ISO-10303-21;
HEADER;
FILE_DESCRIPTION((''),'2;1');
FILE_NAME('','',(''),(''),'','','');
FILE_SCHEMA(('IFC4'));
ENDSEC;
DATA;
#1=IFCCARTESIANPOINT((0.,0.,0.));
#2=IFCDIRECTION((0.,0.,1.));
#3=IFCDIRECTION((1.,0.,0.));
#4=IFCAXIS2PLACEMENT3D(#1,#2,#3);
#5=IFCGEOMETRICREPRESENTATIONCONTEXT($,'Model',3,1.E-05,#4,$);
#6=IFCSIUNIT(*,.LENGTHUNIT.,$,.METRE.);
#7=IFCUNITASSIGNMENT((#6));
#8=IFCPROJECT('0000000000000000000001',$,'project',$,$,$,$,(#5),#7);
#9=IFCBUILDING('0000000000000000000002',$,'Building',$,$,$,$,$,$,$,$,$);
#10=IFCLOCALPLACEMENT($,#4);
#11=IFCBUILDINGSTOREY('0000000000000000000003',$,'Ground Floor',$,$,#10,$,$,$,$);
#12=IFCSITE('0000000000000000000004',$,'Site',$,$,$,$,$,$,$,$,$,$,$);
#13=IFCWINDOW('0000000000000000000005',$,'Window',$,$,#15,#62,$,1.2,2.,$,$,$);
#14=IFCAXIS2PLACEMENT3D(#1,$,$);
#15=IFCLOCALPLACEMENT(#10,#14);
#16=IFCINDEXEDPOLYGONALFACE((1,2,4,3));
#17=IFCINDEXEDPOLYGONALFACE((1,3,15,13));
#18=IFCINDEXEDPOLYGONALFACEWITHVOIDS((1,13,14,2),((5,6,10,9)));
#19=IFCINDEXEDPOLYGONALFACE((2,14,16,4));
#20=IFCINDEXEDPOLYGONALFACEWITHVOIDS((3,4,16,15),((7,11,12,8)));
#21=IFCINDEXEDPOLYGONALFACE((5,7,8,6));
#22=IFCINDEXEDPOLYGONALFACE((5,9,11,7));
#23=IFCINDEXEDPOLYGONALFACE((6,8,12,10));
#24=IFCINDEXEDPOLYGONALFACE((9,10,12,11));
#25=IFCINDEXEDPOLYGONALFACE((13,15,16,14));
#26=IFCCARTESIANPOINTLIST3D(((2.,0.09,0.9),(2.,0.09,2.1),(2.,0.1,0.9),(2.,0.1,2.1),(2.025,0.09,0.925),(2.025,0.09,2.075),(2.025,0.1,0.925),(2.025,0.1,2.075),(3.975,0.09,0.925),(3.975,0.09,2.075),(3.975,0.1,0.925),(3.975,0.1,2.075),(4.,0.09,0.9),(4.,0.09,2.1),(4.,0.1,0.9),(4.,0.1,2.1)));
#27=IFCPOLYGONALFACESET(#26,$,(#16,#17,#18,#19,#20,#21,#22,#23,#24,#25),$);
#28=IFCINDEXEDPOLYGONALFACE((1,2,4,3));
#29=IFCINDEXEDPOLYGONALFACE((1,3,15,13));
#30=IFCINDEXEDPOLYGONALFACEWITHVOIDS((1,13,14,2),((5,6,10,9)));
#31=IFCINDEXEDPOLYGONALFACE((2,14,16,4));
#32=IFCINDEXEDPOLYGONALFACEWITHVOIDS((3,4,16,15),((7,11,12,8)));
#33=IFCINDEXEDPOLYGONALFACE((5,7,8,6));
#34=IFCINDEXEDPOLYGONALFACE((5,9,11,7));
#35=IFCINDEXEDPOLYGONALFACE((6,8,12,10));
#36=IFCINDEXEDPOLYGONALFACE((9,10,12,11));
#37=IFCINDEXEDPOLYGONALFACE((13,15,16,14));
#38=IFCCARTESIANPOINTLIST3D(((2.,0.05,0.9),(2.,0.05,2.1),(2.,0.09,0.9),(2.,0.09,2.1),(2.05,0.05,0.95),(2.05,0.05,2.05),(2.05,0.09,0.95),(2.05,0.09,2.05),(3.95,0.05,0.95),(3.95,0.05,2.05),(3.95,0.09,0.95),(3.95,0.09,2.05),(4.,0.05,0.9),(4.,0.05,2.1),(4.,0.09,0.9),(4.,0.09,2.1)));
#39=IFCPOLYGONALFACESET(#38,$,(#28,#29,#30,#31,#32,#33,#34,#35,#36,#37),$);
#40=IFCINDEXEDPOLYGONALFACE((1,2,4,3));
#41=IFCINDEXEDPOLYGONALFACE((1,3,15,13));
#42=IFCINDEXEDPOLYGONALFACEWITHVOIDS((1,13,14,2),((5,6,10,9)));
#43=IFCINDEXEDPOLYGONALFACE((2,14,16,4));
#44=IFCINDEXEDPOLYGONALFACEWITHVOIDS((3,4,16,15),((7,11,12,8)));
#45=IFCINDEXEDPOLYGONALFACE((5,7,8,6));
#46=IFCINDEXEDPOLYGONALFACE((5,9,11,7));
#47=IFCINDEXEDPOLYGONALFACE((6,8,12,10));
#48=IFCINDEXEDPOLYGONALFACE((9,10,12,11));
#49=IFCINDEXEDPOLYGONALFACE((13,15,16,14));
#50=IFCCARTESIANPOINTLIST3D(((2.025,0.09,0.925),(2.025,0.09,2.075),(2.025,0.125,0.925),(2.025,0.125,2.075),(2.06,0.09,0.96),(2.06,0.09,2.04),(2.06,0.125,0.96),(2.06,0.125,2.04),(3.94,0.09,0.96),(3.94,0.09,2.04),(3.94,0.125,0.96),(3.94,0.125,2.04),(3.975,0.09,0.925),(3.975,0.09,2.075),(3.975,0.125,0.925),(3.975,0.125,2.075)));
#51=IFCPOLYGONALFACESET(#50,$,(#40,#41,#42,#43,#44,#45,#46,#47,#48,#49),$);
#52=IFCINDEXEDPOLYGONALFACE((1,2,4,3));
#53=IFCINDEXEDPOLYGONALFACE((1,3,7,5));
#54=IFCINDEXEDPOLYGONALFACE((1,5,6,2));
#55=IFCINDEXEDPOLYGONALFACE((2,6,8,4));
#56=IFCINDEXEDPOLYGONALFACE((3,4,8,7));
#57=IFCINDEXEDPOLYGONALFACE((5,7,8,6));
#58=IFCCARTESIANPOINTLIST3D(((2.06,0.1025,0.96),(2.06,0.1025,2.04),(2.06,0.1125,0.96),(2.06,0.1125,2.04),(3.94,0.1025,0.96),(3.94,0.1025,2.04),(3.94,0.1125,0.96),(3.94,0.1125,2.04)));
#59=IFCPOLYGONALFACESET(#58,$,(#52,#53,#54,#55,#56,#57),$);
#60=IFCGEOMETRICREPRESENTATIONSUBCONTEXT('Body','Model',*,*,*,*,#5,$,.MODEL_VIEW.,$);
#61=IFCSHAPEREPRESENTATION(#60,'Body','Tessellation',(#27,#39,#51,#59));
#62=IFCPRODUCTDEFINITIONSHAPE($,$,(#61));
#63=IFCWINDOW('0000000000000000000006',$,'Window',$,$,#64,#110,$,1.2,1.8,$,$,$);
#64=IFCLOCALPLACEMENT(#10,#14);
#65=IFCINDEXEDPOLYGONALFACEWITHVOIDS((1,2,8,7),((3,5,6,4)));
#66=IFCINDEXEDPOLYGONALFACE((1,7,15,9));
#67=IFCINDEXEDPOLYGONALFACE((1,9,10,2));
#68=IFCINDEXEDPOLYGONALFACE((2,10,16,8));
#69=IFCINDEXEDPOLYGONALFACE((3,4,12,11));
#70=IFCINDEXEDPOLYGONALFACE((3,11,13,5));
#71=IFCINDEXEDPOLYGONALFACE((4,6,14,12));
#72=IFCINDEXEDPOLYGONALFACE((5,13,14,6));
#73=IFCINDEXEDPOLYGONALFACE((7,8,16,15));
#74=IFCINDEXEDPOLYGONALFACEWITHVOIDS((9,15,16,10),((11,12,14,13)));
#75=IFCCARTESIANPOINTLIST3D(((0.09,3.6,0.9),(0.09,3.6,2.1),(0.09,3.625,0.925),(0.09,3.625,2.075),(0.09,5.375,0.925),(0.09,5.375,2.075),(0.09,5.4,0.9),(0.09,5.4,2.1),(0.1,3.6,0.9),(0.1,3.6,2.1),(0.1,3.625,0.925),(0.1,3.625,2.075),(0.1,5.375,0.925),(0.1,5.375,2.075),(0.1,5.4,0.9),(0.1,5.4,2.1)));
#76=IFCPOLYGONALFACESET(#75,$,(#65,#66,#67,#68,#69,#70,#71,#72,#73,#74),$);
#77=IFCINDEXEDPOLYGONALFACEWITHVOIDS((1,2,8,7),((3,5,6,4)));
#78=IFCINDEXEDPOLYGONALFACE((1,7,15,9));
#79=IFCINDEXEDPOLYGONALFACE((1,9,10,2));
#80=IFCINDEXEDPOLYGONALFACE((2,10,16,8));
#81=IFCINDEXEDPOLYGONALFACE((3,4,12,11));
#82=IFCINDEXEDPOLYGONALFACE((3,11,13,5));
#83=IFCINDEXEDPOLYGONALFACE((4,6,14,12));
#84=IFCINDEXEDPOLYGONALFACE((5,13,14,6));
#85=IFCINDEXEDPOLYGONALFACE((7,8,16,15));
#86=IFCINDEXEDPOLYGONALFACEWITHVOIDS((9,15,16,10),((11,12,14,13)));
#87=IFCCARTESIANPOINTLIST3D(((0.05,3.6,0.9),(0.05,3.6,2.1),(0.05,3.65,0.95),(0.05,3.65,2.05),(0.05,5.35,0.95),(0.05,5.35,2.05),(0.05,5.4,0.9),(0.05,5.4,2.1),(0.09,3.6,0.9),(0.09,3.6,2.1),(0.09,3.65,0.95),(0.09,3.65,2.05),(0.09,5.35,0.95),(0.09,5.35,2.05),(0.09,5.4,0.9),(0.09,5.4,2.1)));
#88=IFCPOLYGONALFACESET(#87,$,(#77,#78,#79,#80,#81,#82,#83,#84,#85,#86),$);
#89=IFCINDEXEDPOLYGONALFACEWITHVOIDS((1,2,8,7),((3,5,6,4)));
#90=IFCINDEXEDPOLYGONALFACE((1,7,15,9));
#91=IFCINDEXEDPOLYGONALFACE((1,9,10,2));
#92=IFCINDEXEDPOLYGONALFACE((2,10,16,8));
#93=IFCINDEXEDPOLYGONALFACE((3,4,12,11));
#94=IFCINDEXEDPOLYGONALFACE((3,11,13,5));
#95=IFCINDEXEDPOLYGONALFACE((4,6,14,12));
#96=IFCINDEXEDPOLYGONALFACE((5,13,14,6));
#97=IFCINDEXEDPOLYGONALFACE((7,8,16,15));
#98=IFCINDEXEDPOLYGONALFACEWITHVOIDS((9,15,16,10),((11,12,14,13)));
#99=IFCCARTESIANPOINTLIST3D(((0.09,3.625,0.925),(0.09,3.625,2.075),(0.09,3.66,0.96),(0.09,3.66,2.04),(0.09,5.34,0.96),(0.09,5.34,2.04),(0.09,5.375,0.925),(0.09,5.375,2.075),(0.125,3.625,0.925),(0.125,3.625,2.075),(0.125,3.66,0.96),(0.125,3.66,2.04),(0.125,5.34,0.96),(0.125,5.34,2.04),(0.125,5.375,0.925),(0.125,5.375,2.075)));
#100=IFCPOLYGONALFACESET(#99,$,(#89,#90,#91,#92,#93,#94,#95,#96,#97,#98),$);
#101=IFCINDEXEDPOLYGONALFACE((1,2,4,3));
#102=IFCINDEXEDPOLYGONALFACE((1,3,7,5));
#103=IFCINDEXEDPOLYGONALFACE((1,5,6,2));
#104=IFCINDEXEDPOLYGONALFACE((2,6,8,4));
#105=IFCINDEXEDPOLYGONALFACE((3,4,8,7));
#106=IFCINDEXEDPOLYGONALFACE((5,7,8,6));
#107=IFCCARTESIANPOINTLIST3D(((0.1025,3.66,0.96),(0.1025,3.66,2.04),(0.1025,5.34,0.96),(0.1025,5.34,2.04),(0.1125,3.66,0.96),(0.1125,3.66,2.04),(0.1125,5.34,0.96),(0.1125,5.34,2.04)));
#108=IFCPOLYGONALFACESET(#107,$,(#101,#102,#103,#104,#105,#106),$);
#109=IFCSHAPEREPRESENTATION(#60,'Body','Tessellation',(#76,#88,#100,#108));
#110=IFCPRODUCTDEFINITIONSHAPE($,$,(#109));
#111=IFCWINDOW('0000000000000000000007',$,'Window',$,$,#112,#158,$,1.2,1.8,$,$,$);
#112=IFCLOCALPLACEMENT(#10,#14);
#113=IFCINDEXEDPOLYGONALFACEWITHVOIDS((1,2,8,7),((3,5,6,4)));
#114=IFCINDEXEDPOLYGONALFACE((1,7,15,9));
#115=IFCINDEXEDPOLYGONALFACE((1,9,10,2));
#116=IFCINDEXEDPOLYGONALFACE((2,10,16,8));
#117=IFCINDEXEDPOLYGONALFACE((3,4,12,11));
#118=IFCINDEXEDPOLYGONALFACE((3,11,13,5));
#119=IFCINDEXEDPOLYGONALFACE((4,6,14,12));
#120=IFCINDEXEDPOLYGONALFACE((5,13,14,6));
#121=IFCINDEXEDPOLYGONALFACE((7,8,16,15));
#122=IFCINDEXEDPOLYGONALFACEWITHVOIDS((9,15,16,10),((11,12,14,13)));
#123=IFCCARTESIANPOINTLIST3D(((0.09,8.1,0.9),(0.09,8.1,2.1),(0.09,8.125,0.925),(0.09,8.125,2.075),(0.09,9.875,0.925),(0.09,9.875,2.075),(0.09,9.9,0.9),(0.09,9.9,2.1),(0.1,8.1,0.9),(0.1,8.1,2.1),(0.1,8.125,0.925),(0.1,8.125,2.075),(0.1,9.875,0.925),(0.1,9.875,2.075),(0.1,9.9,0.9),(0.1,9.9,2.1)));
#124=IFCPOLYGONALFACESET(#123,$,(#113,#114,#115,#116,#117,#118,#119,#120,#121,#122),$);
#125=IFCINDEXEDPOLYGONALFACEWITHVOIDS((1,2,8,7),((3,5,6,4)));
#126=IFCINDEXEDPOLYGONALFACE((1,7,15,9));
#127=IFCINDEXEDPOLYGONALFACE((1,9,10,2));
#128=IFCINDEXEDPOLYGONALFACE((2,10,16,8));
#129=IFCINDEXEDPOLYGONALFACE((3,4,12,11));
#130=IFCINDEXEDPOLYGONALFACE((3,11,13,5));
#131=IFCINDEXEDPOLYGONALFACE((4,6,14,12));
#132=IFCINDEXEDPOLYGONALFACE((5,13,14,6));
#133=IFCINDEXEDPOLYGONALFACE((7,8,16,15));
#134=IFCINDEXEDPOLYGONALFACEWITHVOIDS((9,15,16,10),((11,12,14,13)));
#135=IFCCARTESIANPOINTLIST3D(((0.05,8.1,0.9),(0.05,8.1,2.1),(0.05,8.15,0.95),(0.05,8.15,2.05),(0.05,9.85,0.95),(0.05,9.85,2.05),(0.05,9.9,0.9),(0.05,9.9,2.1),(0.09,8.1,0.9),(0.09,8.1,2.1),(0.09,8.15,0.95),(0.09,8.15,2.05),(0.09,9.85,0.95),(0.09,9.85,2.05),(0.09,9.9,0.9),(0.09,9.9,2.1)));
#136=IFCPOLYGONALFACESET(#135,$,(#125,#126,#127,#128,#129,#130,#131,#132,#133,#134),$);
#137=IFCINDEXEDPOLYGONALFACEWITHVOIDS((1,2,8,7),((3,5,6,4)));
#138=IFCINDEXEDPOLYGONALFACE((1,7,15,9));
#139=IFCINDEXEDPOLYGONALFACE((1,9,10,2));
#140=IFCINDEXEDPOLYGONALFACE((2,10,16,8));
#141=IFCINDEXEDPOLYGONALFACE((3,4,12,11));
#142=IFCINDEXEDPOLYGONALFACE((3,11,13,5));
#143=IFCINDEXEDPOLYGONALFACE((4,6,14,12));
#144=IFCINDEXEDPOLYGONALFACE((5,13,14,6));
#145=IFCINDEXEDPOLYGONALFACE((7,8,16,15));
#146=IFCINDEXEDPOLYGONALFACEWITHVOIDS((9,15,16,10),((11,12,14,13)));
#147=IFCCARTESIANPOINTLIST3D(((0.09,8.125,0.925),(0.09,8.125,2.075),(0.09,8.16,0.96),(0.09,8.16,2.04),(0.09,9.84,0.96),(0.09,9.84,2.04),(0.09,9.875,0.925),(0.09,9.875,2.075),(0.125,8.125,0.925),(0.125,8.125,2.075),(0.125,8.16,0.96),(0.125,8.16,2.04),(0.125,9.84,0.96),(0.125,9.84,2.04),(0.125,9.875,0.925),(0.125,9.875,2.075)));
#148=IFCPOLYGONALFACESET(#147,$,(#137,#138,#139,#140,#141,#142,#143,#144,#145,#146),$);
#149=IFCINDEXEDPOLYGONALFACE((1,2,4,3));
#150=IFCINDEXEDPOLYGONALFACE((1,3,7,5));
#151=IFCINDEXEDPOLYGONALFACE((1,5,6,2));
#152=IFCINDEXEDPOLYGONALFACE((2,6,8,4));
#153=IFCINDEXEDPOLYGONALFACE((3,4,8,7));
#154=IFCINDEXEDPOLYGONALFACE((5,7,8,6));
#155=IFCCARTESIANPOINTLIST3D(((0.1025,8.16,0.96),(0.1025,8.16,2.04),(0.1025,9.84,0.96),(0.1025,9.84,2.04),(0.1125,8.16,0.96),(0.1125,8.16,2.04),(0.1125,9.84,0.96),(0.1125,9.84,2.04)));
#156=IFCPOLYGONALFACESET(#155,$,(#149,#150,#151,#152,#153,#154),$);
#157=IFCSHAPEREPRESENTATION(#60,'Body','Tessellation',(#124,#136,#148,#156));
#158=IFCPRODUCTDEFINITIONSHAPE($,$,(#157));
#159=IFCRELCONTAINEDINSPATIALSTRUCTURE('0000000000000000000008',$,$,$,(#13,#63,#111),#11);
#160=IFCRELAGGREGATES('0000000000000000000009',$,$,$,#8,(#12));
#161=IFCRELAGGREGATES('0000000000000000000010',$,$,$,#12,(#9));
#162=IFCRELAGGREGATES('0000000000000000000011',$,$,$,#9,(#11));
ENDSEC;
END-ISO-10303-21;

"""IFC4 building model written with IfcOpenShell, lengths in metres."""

from ifc_helpers import new_model, si_unit, frame, origin_with_axes, place, context, subcontext, project, spatial, line, indexed_curve, outline, extrude, element, save


model = new_model("IFC4")

# Units and contexts
model_context = context("Model", 3, precision=1e-05, world=origin_with_axes())
body_context = subcontext(model_context, "Body", "Model", "MODEL_VIEW")
ifc_project = project(units=[si_unit("LENGTHUNIT", "METRE")], contexts=[model_context])

# Site, building, storey
site = spatial("IfcSite", under=ifc_project, Name="Site")
building = spatial("IfcBuilding", under=site, Name="Building")
storey_placement = place(None, origin_with_axes())
storey = spatial("IfcBuildingStorey", under=building, at=storey_placement, Name="Ground Floor")

# Windows
window_placement = place(storey_placement, frame((2.0, 0.0, 0.9), z_axis=(0.0, 0.0, 1.0), x_axis=(1.0, 0.0, 0.0)))
element("IfcWindow", 1, at=window_placement, inside=storey, Name="Window", OverallHeight=1.2, OverallWidth=2.0, context=body_context, shape_type="SweptSolid", body=[
    extrude(outline(indexed_curve([(0.0, 0.0), (2.0, 0.0), (2.0, 1.2), (0.0, 1.2)], segments=[line(1, 2, 3, 4, 1)]), holes=[indexed_curve([(0.025, 0.025), (1.975, 0.025), (1.975, 1.175), (0.025, 1.175)], segments=[line(1, 2, 3, 4, 1)])]), frame((0.0, 0.09, 0.0), z_axis=(0.0, -1.0, 0.0), x_axis=(1.0, 0.0, 0.0)), (0.0, 0.0, -1.0), 0.01),
    extrude(outline(indexed_curve([(0.0, 0.0), (2.0, 0.0), (2.0, 1.2), (0.0, 1.2)], segments=[line(1, 2, 3, 4, 1)]), holes=[indexed_curve([(0.05, 0.05), (1.95, 0.05), (1.95, 1.15), (0.05, 1.15)], segments=[line(1, 2, 3, 4, 1)])]), frame((0.0, 0.05, 0.0), z_axis=(0.0, -1.0, 0.0), x_axis=(1.0, 0.0, 0.0)), (0.0, 0.0, -1.0), 0.04),
    extrude(outline(indexed_curve([(0.0, 0.0), (1.95, 0.0), (1.95, 1.15), (0.0, 1.15)], segments=[line(1, 2, 3, 4, 1)]), holes=[indexed_curve([(0.035, 0.035), (1.915, 0.035), (1.915, 1.115), (0.035, 1.115)], segments=[line(1, 2, 3, 4, 1)])]), frame((0.025, 0.09, 0.025), z_axis=(0.0, -1.0, 0.0), x_axis=(1.0, 0.0, 0.0)), (0.0, 0.0, -1.0), 0.035),
    extrude(outline(indexed_curve([(0.035, 0.035), (1.915, 0.035), (1.915, 1.115), (0.035, 1.115)], segments=[line(1, 2, 3, 4, 1)])), frame((0.025, 0.1025, 0.025), z_axis=(0.0, -1.0, 0.0), x_axis=(1.0, 0.0, 0.0)), (0.0, 0.0, -1.0), 0.01),
])
for number, where, z_axis, x_axis, name in (
    (2, (0.0, 5.4, 0.9), (0.0, 0.0, 1.0), (0.0, -1.0, 0.0), "Window"),
    (3, (0.0, 9.9, 0.9), (0.0, 0.0, 1.0), (0.0, -1.0, 0.0), "Window"),
):
    element("IfcWindow", number, at=place(storey_placement, frame(where, z_axis=z_axis, x_axis=x_axis)), inside=storey, Name=name, OverallHeight=1.2, OverallWidth=1.8, context=body_context, shape_type="SweptSolid", body=[
        extrude(outline(indexed_curve([(0.0, 0.0), (1.8, 0.0), (1.8, 1.2), (0.0, 1.2)], segments=[line(1, 2, 3, 4, 1)]), holes=[indexed_curve([(0.025, 0.025), (1.775, 0.025), (1.775, 1.175), (0.025, 1.175)], segments=[line(1, 2, 3, 4, 1)])]), frame((0.0, 0.09, 0.0), z_axis=(0.0, -1.0, 0.0), x_axis=(1.0, 0.0, 0.0)), (0.0, 0.0, -1.0), 0.01),
        extrude(outline(indexed_curve([(0.0, 0.0), (1.8, 0.0), (1.8, 1.2), (0.0, 1.2)], segments=[line(1, 2, 3, 4, 1)]), holes=[indexed_curve([(0.05, 0.05), (1.75, 0.05), (1.75, 1.15), (0.05, 1.15)], segments=[line(1, 2, 3, 4, 1)])]), frame((0.0, 0.05, 0.0), z_axis=(0.0, -1.0, 0.0), x_axis=(1.0, 0.0, 0.0)), (0.0, 0.0, -1.0), 0.04),
        extrude(outline(indexed_curve([(0.0, 0.0), (1.75, 0.0), (1.75, 1.15), (0.0, 1.15)], segments=[line(1, 2, 3, 4, 1)]), holes=[indexed_curve([(0.035, 0.035), (1.715, 0.035), (1.715, 1.115), (0.035, 1.115)], segments=[line(1, 2, 3, 4, 1)])]), frame((0.025, 0.09, 0.025), z_axis=(0.0, -1.0, 0.0), x_axis=(1.0, 0.0, 0.0)), (0.0, 0.0, -1.0), 0.035),
        extrude(outline(indexed_curve([(0.035, 0.035), (1.715, 0.035), (1.715, 1.115), (0.035, 1.115)], segments=[line(1, 2, 3, 4, 1)])), frame((0.025, 0.1025, 0.025), z_axis=(0.0, -1.0, 0.0), x_axis=(1.0, 0.0, 0.0)), (0.0, 0.0, -1.0), 0.01),
    ])

save(model, "model.ifc")
